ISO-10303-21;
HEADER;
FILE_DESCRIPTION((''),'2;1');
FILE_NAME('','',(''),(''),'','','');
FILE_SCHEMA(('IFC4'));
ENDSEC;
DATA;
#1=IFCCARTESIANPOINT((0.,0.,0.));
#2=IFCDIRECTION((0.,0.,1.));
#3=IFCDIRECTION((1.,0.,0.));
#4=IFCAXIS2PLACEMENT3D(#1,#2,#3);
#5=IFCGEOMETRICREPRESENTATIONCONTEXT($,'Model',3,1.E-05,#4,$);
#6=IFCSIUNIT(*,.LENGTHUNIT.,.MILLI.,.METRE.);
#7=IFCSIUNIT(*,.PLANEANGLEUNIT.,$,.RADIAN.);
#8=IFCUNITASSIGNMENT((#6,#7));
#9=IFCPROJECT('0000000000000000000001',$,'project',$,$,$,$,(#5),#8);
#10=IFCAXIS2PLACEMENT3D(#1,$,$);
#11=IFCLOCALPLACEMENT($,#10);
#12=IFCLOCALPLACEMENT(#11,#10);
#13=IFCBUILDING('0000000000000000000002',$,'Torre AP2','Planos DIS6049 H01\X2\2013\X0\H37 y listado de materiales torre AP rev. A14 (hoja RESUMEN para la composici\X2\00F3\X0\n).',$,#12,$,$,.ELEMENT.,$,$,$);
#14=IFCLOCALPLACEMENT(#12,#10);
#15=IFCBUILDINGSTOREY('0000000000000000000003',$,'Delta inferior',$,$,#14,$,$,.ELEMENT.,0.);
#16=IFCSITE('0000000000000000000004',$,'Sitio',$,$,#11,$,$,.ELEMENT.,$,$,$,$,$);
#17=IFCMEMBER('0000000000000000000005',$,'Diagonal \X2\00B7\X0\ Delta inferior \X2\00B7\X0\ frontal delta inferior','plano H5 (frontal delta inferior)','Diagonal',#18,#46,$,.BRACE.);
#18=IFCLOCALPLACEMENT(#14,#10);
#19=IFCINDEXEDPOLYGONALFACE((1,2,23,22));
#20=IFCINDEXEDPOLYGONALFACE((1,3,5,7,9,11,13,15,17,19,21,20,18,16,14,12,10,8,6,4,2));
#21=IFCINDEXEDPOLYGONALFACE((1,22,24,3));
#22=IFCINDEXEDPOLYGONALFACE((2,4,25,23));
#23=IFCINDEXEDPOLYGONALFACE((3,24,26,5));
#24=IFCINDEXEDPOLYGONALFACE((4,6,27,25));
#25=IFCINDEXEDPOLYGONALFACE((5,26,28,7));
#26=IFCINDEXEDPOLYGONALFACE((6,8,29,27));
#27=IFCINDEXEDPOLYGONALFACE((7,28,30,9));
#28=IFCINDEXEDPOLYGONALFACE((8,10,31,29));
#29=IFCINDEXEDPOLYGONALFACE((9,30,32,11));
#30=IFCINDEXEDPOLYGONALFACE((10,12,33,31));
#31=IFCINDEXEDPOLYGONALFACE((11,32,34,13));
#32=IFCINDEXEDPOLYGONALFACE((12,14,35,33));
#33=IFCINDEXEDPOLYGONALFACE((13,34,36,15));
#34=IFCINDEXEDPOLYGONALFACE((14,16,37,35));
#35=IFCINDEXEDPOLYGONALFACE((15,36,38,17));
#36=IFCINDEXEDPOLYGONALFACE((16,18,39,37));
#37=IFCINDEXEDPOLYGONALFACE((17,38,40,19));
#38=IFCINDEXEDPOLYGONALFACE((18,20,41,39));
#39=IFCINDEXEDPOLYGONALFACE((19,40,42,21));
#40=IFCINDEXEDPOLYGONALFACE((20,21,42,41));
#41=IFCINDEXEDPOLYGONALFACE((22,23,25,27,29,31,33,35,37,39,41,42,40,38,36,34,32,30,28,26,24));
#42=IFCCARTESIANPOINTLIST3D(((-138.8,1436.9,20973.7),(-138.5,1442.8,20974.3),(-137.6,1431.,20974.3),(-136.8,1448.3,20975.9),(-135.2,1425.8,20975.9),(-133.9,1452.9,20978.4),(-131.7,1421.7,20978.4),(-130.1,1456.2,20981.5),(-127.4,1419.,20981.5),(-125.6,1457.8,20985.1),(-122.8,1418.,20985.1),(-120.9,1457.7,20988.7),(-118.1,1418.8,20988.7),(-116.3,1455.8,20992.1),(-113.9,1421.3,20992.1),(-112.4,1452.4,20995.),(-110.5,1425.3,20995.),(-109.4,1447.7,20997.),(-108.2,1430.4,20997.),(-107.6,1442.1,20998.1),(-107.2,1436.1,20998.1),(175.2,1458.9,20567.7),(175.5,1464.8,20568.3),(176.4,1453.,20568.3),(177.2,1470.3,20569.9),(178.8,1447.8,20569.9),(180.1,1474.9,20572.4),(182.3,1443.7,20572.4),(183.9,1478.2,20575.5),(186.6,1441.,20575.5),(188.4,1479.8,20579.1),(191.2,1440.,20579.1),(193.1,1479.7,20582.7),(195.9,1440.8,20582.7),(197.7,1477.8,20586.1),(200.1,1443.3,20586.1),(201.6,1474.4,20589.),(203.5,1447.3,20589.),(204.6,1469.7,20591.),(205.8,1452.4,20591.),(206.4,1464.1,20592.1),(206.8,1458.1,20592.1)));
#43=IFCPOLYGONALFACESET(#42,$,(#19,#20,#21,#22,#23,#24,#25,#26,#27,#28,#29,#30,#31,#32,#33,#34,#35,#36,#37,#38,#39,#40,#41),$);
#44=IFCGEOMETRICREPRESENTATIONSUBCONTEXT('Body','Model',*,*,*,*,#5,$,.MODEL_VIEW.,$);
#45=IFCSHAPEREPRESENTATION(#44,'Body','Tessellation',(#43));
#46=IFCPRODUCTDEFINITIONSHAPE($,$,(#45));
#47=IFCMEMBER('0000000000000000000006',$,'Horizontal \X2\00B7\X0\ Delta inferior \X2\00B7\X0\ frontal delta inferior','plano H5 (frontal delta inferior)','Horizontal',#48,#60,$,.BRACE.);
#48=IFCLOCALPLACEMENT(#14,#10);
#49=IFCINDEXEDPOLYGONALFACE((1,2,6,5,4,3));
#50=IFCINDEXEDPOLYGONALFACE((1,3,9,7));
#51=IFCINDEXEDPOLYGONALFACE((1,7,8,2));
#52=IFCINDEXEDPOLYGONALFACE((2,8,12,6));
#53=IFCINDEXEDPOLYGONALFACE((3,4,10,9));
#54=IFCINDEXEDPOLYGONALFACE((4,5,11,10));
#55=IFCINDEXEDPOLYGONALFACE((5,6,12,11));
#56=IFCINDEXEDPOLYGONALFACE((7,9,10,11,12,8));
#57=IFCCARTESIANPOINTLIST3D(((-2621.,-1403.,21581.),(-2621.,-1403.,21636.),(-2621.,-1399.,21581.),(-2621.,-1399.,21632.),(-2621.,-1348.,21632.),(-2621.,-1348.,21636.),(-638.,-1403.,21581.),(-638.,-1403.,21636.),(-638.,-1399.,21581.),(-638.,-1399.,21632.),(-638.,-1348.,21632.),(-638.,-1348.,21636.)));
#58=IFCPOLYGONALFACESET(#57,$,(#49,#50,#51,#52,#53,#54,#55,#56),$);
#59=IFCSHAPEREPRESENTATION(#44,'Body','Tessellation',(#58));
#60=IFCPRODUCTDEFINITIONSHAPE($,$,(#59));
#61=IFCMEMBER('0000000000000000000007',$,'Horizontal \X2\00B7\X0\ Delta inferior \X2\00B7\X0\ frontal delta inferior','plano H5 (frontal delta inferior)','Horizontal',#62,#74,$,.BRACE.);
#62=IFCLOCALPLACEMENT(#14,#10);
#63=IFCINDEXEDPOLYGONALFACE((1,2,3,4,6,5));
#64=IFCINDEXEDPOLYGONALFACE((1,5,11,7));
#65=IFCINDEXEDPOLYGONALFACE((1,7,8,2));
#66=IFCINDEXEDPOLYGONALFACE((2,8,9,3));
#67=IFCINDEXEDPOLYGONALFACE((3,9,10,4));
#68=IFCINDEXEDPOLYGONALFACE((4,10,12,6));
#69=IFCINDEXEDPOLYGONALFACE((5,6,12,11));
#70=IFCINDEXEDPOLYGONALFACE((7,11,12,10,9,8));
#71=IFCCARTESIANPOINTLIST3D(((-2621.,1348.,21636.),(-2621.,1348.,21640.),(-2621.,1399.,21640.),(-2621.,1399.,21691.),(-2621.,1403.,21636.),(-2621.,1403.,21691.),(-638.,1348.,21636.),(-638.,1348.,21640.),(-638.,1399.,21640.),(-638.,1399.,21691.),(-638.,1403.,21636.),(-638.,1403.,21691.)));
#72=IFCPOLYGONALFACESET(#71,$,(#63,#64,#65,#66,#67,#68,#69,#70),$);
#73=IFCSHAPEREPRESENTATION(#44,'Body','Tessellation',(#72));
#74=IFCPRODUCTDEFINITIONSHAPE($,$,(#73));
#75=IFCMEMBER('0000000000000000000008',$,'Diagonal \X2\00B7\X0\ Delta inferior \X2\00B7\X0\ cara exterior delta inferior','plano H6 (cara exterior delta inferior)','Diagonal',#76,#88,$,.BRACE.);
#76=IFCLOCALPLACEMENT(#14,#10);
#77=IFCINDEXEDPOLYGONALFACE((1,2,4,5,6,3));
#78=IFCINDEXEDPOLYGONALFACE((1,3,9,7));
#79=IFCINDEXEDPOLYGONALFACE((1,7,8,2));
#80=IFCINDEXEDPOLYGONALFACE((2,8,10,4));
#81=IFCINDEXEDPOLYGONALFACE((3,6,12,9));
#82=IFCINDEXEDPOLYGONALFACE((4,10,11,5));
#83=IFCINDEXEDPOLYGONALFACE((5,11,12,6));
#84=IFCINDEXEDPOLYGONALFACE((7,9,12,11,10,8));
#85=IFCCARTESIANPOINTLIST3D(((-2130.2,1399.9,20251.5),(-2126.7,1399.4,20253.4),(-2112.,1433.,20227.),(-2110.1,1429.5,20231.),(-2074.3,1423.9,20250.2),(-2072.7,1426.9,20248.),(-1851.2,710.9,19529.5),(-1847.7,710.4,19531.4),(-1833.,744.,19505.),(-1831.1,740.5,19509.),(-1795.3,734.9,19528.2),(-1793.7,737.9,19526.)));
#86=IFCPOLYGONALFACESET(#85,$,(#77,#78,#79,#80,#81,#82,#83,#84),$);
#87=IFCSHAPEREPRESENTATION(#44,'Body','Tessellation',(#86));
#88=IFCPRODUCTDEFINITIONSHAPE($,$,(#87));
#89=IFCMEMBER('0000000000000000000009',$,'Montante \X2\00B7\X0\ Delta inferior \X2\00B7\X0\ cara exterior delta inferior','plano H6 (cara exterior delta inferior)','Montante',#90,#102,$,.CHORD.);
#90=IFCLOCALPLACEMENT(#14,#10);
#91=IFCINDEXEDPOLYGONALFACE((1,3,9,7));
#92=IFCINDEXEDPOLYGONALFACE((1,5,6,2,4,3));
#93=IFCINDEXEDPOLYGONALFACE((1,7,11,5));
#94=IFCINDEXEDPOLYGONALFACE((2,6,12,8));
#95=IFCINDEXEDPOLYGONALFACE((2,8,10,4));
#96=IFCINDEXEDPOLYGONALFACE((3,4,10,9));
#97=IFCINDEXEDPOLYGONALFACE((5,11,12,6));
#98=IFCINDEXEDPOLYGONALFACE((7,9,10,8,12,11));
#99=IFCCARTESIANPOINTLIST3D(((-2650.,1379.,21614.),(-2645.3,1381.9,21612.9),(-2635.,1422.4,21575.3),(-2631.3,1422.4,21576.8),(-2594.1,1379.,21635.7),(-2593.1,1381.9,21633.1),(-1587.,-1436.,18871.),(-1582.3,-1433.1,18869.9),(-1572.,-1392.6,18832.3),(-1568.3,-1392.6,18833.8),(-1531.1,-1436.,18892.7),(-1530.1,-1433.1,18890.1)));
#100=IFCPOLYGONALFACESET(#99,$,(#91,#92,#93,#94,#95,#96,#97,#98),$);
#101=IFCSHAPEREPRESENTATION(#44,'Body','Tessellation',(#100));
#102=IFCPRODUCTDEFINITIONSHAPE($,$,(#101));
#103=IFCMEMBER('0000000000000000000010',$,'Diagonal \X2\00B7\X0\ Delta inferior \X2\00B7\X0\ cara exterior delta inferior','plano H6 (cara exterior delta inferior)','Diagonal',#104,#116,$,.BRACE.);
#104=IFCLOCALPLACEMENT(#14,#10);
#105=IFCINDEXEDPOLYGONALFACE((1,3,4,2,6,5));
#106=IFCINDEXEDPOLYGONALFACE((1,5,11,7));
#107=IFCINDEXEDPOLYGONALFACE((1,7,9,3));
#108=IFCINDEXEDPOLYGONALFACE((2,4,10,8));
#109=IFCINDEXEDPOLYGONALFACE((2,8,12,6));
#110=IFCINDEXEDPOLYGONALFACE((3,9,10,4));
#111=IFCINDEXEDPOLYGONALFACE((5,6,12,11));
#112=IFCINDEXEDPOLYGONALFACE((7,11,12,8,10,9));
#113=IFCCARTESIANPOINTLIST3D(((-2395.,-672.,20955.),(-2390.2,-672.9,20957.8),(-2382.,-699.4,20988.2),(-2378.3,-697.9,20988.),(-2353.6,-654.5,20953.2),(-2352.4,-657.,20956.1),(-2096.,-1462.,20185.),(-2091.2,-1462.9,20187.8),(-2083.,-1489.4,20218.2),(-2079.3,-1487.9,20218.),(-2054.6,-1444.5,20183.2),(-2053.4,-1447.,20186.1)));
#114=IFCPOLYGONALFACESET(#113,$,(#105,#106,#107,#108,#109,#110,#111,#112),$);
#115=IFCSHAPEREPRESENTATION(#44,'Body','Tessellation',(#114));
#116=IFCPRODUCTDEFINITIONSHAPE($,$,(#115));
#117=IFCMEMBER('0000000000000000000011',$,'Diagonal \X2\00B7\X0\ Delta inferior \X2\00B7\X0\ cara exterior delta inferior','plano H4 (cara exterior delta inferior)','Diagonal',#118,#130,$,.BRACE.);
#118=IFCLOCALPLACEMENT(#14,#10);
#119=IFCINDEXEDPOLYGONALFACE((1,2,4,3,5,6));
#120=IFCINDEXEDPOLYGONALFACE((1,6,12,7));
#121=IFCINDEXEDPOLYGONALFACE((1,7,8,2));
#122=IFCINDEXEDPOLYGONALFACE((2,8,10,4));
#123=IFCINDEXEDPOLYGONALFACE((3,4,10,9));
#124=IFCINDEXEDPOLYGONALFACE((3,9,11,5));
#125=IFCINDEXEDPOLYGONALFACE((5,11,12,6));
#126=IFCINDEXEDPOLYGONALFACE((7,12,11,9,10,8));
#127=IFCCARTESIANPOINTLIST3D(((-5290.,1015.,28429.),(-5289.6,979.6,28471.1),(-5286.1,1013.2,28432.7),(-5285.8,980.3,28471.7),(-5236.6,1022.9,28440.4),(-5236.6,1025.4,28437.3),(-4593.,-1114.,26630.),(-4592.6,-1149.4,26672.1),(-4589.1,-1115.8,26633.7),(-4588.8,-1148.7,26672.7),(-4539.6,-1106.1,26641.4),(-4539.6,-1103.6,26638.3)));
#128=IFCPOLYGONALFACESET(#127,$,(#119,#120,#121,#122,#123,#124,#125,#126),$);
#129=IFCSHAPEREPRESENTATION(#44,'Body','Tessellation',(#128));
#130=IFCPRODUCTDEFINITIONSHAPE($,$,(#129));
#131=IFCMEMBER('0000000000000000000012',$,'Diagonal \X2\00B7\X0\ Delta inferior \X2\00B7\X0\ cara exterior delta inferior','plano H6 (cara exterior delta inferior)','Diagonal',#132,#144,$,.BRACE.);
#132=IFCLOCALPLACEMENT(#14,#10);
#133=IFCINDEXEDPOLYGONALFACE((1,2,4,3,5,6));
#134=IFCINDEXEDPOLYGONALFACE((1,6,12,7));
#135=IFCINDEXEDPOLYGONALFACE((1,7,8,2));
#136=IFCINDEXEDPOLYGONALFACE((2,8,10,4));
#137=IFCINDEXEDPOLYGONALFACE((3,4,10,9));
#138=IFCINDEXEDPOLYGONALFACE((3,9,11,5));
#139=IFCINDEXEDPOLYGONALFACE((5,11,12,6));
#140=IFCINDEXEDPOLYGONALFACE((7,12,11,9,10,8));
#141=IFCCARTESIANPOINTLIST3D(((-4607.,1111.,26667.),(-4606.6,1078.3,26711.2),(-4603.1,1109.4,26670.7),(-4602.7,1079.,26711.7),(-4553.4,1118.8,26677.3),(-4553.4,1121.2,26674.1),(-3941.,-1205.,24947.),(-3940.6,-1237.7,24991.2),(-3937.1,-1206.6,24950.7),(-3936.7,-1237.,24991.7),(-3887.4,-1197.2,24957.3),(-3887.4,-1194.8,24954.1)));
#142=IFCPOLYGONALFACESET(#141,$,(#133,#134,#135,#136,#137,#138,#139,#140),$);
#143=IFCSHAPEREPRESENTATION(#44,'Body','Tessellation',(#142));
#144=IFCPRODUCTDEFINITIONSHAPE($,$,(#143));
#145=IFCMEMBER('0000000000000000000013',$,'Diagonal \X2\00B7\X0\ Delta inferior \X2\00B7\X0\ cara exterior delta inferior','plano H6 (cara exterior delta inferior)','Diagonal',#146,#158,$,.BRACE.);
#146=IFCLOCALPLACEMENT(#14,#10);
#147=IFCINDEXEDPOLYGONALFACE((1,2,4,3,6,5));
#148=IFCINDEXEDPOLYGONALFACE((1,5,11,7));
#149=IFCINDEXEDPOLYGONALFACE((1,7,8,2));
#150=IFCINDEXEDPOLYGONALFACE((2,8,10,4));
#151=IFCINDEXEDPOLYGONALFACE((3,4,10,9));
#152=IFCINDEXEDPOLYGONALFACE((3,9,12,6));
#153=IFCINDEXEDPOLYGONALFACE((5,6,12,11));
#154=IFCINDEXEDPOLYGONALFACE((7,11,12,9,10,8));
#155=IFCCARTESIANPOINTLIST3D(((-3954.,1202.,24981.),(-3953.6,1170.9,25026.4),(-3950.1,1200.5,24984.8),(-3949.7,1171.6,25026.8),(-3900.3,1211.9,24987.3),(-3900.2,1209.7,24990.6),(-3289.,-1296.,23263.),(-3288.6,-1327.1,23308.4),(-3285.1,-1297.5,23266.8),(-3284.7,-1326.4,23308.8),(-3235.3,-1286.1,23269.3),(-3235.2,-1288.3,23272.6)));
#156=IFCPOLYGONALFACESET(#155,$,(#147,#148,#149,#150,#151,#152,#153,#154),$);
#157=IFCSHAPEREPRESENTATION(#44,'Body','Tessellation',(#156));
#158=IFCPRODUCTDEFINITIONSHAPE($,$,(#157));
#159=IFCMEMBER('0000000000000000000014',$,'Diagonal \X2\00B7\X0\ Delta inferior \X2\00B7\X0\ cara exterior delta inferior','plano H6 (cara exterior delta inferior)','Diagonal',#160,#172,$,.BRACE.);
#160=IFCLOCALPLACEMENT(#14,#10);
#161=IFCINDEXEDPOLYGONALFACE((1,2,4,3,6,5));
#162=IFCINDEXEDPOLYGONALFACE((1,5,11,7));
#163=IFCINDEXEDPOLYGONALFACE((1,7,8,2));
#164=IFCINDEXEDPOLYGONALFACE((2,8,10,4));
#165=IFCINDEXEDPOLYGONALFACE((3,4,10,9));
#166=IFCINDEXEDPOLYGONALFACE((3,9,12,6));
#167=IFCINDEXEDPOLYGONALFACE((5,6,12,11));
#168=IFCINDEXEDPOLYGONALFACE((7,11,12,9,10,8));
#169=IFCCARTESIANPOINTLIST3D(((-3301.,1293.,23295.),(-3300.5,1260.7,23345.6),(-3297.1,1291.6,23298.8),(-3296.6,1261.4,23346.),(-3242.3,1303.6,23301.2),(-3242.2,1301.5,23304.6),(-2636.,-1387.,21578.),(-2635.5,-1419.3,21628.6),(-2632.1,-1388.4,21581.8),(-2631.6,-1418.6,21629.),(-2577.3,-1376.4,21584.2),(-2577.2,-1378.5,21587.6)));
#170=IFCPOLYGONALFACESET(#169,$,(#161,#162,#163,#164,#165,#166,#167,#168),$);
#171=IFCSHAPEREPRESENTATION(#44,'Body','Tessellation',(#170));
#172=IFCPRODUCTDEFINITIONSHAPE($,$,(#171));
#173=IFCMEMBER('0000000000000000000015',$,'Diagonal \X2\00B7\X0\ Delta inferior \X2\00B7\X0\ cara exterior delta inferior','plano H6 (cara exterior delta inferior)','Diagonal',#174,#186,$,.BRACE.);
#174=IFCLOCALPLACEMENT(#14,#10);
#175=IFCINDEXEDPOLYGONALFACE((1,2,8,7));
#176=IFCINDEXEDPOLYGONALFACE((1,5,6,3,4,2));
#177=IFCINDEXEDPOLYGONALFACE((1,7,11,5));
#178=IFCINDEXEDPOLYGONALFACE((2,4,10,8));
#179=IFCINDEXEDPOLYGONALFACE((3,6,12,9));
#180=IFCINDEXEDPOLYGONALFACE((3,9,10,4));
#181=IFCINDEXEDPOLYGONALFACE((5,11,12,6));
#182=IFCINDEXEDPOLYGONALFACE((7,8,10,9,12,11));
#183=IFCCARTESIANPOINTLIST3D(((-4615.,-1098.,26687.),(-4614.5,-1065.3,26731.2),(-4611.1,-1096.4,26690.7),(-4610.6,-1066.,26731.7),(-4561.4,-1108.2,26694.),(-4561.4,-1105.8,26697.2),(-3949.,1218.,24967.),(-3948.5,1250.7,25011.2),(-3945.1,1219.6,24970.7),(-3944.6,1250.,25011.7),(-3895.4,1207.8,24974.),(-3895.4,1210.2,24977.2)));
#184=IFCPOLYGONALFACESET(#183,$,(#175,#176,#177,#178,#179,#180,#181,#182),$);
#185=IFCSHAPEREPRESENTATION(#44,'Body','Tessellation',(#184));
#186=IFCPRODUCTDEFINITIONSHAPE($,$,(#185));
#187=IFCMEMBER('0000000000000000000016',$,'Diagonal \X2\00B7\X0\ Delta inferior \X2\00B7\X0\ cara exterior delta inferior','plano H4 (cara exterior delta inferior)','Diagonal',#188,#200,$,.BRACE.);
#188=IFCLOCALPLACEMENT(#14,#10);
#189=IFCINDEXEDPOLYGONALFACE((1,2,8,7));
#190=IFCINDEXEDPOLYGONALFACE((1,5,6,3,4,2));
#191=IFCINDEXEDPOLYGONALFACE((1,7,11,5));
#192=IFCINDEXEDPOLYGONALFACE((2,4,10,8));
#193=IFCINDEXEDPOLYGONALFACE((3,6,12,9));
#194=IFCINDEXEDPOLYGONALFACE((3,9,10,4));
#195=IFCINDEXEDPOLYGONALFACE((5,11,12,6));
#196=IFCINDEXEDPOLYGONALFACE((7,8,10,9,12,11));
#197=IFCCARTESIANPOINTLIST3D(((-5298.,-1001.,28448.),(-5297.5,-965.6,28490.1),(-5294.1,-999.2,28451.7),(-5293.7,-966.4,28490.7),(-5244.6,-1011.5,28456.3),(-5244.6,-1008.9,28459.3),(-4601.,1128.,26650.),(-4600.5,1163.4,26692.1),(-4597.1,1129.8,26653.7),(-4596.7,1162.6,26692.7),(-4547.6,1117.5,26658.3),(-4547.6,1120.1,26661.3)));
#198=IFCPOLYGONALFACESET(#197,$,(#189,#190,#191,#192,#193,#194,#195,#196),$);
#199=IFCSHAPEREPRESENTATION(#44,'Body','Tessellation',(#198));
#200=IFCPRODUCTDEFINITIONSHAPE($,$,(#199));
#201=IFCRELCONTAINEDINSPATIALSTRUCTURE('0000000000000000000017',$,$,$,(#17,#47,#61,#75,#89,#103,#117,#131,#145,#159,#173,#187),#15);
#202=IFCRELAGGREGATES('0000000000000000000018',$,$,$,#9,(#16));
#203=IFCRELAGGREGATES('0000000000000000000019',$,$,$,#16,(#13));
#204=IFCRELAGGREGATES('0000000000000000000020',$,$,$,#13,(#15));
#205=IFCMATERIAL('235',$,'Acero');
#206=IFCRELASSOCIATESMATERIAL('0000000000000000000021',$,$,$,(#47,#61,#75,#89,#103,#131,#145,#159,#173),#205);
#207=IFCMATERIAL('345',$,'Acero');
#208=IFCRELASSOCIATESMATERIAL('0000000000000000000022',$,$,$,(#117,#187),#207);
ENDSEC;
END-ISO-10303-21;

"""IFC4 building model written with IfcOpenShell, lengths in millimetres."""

from ifc_helpers import new_model, si_unit, frame, frame_2d, origin, origin_with_axes, place, context, subcontext, project, spatial, circle, l_section, extrude, material, element, save


model = new_model("IFC4")

# Units and contexts
model_context = context("Model", 3, precision=1e-05, world=origin_with_axes())
body_context = subcontext(model_context, "Body", "Model", "MODEL_VIEW")
ifc_project = project(units=[si_unit("LENGTHUNIT", "METRE", prefix="MILLI"), si_unit("PLANEANGLEUNIT", "RADIAN")], contexts=[model_context])

# Site, building, storey
site_placement = place(None, origin())
site = spatial("IfcSite", under=ifc_project, at=site_placement, Name="Sitio", CompositionType="ELEMENT")
building_placement = place(site_placement, origin())
building = spatial("IfcBuilding", under=site, at=building_placement, Name="Torre AP2", Description="Planos DIS6049 H01–H37 y listado de materiales torre AP rev. A14 (hoja RESUMEN para la composición).", CompositionType="ELEMENT")
storey_placement = place(building_placement, origin())
storey = spatial("IfcBuildingStorey", under=building, at=storey_placement, Name="Delta inferior", CompositionType="ELEMENT", Elevation=0.0)

# Members
ifc_material_1 = material(Name="235", Category="Acero")
for number, where, z_axis, x_axis, name in (
    (1, (191.0, 1460.0, 20580.0), (-0.611219, -0.042824, 0.790302), (0.011492, -0.99891, -0.04524), "Diagonal · Delta inferior · frontal delta inferior"),
):
    element("IfcMember", number, at=place(storey_placement, frame(where, z_axis=z_axis, x_axis=x_axis)), inside=storey, Name=name, Description="plano H5 (frontal delta inferior)", ObjectType="Diagonal", PredefinedType="BRACE", context=body_context, shape_type="SweptSolid", body=[
        extrude(circle(Radius=20.0), None, (0.0, 0.0, 1.0), 513.7),
    ])
for number, where, z_axis, x_axis, name in (
    (2, (-638.0, -1403.0, 21636.0), (-1.0, 0.0, 0.0), (0.0, 1.0, 0.0), "Horizontal · Delta inferior · frontal delta inferior"),
    (3, (-638.0, 1403.0, 21636.0), (-1.0, 0.0, 0.0), (0.0, -1.0, 0.0), "Horizontal · Delta inferior · frontal delta inferior"),
):
    element("IfcMember", number, at=place(storey_placement, frame(where, z_axis=z_axis, x_axis=x_axis)), inside=storey, material=ifc_material_1, Name=name, Description="plano H5 (frontal delta inferior)", ObjectType="Horizontal", PredefinedType="BRACE", context=body_context, shape_type="SweptSolid", body=[
        extrude(l_section(Depth=55.0, Width=55.0, Thickness=4.0, at=frame_2d((27.5, 27.5))), None, (0.0, 0.0, 1.0), 1983.0),
    ])
member_1_placement = place(storey_placement, frame((-2112.0, 1433.0, 20227.0), z_axis=(0.269236, -0.664888, -0.696733), x_axis=(0.873631, -0.135855, 0.46724)))
element("IfcMember", 4, at=member_1_placement, inside=storey, material=ifc_material_1, Name="Diagonal · Delta inferior · cara exterior delta inferior", Description="plano H6 (cara exterior delta inferior)", ObjectType="Diagonal", PredefinedType="BRACE", context=body_context, shape_type="SweptSolid", body=[
    extrude(l_section(Depth=45.0, Width=45.0, Thickness=4.0, at=frame_2d((22.5, 22.5))), None, (0.0, 0.0, 1.0), 1036.3),
])
member_2_placement = place(storey_placement, frame((-2650.0, 1379.0, 21614.0), z_axis=(0.261074, -0.691368, -0.673685), x_axis=(0.249824, 0.722503, -0.644653)))
element("IfcMember", 5, at=member_2_placement, inside=storey, material=ifc_material_1, Name="Montante · Delta inferior · cara exterior delta inferior", Description="plano H6 (cara exterior delta inferior)", ObjectType="Montante", PredefinedType="CHORD", context=body_context, shape_type="SweptSolid", body=[
    extrude(l_section(Depth=60.0, Width=60.0, Thickness=4.0, at=frame_2d((30.0, 30.0))), None, (0.0, 0.0, 1.0), 4071.6),
])
member_3_placement = place(storey_placement, frame((-2395.0, -672.0, 20955.0), z_axis=(0.261597, -0.691176, -0.673678), x_axis=(0.920687, 0.38817, -0.040739)))
element("IfcMember", 6, at=member_3_placement, inside=storey, material=ifc_material_1, Name="Diagonal · Delta inferior · cara exterior delta inferior", Description="plano H6 (cara exterior delta inferior)", ObjectType="Diagonal", PredefinedType="BRACE", context=body_context, shape_type="SweptSolid", body=[
    extrude(l_section(Depth=45.0, Width=45.0, Thickness=4.0, at=frame_2d((22.5, 22.5))), None, (0.0, 0.0, 1.0), 1143.0),
])
ifc_material_2 = material(Name="345", Category="Acero")
member_4_placement = place(storey_placement, frame((-5290.0, 1015.0, 28429.0), z_axis=(0.242593, -0.741005, -0.626147), x_axis=(0.970107, 0.189587, 0.151492)))
element("IfcMember", 7, at=member_4_placement, inside=storey, material=ifc_material_2, Name="Diagonal · Delta inferior · cara exterior delta inferior", Description="plano H4 (cara exterior delta inferior)", ObjectType="Diagonal", PredefinedType="BRACE", context=body_context, shape_type="SweptSolid", body=[
    extrude(l_section(Depth=55.0, Width=55.0, Thickness=4.0, at=frame_2d((27.5, 27.5))), None, (0.0, 0.0, 1.0), 2873.1),
])
member_5_placement = place(storey_placement, frame((-4607.0, 1111.0, 26667.0), z_axis=(0.224946, -0.782244, -0.580941), x_axis=(0.974349, 0.184591, 0.128724)))
element("IfcMember", 8, at=member_5_placement, inside=storey, material=ifc_material_1, Name="Diagonal · Delta inferior · cara exterior delta inferior", Description="plano H6 (cara exterior delta inferior)", ObjectType="Diagonal", PredefinedType="BRACE", context=body_context, shape_type="SweptSolid", body=[
    extrude(l_section(Depth=55.0, Width=55.0, Thickness=4.0, at=frame_2d((27.5, 27.5))), None, (0.0, 0.0, 1.0), 2960.7),
])
member_6_placement = place(storey_placement, frame((-3954.0, 1202.0, 24981.0), z_axis=(0.214252, -0.804812, -0.55351), x_axis=(0.976751, 0.180783, 0.115217)))
element("IfcMember", 9, at=member_6_placement, inside=storey, material=ifc_material_1, Name="Diagonal · Delta inferior · cara exterior delta inferior", Description="plano H6 (cara exterior delta inferior)", ObjectType="Diagonal", PredefinedType="BRACE", context=body_context, shape_type="SweptSolid", body=[
    extrude(l_section(Depth=55.0, Width=55.0, Thickness=4.0, at=frame_2d((27.5, 27.5))), None, (0.0, 0.0, 1.0), 3103.8),
])
member_7_placement = place(storey_placement, frame((-3301.0, 1293.0, 23295.0), z_axis=(0.204517, -0.824217, -0.528052), x_axis=(0.978826, 0.176893, 0.102997)))
element("IfcMember", 10, at=member_7_placement, inside=storey, material=ifc_material_1, Name="Diagonal · Delta inferior · cara exterior delta inferior", Description="plano H6 (cara exterior delta inferior)", ObjectType="Diagonal", PredefinedType="BRACE", context=body_context, shape_type="SweptSolid", body=[
    extrude(l_section(Depth=60.0, Width=60.0, Thickness=4.0, at=frame_2d((30.0, 30.0))), None, (0.0, 0.0, 1.0), 3251.6),
])
member_8_placement = place(storey_placement, frame((-3949.0, 1218.0, 24967.0), z_axis=(-0.224946, -0.782244, 0.580941), x_axis=(0.974336, -0.185683, 0.127247)))
element("IfcMember", 11, at=member_8_placement, inside=storey, material=ifc_material_1, Name="Diagonal · Delta inferior · cara exterior delta inferior", Description="plano H6 (cara exterior delta inferior)", ObjectType="Diagonal", PredefinedType="BRACE", context=body_context, shape_type="SweptSolid", body=[
    extrude(l_section(Depth=55.0, Width=55.0, Thickness=4.0, at=frame_2d((27.5, 27.5))), None, (0.0, 0.0, 1.0), 2960.7),
])
member_9_placement = place(storey_placement, frame((-4601.0, 1128.0, 26650.0), z_axis=(-0.242646, -0.741166, 0.625936), x_axis=(0.97008, -0.190866, 0.150051)))
element("IfcMember", 12, at=member_9_placement, inside=storey, material=ifc_material_2, Name="Diagonal · Delta inferior · cara exterior delta inferior", Description="plano H4 (cara exterior delta inferior)", ObjectType="Diagonal", PredefinedType="BRACE", context=body_context, shape_type="SweptSolid", body=[
    extrude(l_section(Depth=55.0, Width=55.0, Thickness=4.0, at=frame_2d((27.5, 27.5))), None, (0.0, 0.0, 1.0), 2872.5),
])

save(model, "model.ifc")
